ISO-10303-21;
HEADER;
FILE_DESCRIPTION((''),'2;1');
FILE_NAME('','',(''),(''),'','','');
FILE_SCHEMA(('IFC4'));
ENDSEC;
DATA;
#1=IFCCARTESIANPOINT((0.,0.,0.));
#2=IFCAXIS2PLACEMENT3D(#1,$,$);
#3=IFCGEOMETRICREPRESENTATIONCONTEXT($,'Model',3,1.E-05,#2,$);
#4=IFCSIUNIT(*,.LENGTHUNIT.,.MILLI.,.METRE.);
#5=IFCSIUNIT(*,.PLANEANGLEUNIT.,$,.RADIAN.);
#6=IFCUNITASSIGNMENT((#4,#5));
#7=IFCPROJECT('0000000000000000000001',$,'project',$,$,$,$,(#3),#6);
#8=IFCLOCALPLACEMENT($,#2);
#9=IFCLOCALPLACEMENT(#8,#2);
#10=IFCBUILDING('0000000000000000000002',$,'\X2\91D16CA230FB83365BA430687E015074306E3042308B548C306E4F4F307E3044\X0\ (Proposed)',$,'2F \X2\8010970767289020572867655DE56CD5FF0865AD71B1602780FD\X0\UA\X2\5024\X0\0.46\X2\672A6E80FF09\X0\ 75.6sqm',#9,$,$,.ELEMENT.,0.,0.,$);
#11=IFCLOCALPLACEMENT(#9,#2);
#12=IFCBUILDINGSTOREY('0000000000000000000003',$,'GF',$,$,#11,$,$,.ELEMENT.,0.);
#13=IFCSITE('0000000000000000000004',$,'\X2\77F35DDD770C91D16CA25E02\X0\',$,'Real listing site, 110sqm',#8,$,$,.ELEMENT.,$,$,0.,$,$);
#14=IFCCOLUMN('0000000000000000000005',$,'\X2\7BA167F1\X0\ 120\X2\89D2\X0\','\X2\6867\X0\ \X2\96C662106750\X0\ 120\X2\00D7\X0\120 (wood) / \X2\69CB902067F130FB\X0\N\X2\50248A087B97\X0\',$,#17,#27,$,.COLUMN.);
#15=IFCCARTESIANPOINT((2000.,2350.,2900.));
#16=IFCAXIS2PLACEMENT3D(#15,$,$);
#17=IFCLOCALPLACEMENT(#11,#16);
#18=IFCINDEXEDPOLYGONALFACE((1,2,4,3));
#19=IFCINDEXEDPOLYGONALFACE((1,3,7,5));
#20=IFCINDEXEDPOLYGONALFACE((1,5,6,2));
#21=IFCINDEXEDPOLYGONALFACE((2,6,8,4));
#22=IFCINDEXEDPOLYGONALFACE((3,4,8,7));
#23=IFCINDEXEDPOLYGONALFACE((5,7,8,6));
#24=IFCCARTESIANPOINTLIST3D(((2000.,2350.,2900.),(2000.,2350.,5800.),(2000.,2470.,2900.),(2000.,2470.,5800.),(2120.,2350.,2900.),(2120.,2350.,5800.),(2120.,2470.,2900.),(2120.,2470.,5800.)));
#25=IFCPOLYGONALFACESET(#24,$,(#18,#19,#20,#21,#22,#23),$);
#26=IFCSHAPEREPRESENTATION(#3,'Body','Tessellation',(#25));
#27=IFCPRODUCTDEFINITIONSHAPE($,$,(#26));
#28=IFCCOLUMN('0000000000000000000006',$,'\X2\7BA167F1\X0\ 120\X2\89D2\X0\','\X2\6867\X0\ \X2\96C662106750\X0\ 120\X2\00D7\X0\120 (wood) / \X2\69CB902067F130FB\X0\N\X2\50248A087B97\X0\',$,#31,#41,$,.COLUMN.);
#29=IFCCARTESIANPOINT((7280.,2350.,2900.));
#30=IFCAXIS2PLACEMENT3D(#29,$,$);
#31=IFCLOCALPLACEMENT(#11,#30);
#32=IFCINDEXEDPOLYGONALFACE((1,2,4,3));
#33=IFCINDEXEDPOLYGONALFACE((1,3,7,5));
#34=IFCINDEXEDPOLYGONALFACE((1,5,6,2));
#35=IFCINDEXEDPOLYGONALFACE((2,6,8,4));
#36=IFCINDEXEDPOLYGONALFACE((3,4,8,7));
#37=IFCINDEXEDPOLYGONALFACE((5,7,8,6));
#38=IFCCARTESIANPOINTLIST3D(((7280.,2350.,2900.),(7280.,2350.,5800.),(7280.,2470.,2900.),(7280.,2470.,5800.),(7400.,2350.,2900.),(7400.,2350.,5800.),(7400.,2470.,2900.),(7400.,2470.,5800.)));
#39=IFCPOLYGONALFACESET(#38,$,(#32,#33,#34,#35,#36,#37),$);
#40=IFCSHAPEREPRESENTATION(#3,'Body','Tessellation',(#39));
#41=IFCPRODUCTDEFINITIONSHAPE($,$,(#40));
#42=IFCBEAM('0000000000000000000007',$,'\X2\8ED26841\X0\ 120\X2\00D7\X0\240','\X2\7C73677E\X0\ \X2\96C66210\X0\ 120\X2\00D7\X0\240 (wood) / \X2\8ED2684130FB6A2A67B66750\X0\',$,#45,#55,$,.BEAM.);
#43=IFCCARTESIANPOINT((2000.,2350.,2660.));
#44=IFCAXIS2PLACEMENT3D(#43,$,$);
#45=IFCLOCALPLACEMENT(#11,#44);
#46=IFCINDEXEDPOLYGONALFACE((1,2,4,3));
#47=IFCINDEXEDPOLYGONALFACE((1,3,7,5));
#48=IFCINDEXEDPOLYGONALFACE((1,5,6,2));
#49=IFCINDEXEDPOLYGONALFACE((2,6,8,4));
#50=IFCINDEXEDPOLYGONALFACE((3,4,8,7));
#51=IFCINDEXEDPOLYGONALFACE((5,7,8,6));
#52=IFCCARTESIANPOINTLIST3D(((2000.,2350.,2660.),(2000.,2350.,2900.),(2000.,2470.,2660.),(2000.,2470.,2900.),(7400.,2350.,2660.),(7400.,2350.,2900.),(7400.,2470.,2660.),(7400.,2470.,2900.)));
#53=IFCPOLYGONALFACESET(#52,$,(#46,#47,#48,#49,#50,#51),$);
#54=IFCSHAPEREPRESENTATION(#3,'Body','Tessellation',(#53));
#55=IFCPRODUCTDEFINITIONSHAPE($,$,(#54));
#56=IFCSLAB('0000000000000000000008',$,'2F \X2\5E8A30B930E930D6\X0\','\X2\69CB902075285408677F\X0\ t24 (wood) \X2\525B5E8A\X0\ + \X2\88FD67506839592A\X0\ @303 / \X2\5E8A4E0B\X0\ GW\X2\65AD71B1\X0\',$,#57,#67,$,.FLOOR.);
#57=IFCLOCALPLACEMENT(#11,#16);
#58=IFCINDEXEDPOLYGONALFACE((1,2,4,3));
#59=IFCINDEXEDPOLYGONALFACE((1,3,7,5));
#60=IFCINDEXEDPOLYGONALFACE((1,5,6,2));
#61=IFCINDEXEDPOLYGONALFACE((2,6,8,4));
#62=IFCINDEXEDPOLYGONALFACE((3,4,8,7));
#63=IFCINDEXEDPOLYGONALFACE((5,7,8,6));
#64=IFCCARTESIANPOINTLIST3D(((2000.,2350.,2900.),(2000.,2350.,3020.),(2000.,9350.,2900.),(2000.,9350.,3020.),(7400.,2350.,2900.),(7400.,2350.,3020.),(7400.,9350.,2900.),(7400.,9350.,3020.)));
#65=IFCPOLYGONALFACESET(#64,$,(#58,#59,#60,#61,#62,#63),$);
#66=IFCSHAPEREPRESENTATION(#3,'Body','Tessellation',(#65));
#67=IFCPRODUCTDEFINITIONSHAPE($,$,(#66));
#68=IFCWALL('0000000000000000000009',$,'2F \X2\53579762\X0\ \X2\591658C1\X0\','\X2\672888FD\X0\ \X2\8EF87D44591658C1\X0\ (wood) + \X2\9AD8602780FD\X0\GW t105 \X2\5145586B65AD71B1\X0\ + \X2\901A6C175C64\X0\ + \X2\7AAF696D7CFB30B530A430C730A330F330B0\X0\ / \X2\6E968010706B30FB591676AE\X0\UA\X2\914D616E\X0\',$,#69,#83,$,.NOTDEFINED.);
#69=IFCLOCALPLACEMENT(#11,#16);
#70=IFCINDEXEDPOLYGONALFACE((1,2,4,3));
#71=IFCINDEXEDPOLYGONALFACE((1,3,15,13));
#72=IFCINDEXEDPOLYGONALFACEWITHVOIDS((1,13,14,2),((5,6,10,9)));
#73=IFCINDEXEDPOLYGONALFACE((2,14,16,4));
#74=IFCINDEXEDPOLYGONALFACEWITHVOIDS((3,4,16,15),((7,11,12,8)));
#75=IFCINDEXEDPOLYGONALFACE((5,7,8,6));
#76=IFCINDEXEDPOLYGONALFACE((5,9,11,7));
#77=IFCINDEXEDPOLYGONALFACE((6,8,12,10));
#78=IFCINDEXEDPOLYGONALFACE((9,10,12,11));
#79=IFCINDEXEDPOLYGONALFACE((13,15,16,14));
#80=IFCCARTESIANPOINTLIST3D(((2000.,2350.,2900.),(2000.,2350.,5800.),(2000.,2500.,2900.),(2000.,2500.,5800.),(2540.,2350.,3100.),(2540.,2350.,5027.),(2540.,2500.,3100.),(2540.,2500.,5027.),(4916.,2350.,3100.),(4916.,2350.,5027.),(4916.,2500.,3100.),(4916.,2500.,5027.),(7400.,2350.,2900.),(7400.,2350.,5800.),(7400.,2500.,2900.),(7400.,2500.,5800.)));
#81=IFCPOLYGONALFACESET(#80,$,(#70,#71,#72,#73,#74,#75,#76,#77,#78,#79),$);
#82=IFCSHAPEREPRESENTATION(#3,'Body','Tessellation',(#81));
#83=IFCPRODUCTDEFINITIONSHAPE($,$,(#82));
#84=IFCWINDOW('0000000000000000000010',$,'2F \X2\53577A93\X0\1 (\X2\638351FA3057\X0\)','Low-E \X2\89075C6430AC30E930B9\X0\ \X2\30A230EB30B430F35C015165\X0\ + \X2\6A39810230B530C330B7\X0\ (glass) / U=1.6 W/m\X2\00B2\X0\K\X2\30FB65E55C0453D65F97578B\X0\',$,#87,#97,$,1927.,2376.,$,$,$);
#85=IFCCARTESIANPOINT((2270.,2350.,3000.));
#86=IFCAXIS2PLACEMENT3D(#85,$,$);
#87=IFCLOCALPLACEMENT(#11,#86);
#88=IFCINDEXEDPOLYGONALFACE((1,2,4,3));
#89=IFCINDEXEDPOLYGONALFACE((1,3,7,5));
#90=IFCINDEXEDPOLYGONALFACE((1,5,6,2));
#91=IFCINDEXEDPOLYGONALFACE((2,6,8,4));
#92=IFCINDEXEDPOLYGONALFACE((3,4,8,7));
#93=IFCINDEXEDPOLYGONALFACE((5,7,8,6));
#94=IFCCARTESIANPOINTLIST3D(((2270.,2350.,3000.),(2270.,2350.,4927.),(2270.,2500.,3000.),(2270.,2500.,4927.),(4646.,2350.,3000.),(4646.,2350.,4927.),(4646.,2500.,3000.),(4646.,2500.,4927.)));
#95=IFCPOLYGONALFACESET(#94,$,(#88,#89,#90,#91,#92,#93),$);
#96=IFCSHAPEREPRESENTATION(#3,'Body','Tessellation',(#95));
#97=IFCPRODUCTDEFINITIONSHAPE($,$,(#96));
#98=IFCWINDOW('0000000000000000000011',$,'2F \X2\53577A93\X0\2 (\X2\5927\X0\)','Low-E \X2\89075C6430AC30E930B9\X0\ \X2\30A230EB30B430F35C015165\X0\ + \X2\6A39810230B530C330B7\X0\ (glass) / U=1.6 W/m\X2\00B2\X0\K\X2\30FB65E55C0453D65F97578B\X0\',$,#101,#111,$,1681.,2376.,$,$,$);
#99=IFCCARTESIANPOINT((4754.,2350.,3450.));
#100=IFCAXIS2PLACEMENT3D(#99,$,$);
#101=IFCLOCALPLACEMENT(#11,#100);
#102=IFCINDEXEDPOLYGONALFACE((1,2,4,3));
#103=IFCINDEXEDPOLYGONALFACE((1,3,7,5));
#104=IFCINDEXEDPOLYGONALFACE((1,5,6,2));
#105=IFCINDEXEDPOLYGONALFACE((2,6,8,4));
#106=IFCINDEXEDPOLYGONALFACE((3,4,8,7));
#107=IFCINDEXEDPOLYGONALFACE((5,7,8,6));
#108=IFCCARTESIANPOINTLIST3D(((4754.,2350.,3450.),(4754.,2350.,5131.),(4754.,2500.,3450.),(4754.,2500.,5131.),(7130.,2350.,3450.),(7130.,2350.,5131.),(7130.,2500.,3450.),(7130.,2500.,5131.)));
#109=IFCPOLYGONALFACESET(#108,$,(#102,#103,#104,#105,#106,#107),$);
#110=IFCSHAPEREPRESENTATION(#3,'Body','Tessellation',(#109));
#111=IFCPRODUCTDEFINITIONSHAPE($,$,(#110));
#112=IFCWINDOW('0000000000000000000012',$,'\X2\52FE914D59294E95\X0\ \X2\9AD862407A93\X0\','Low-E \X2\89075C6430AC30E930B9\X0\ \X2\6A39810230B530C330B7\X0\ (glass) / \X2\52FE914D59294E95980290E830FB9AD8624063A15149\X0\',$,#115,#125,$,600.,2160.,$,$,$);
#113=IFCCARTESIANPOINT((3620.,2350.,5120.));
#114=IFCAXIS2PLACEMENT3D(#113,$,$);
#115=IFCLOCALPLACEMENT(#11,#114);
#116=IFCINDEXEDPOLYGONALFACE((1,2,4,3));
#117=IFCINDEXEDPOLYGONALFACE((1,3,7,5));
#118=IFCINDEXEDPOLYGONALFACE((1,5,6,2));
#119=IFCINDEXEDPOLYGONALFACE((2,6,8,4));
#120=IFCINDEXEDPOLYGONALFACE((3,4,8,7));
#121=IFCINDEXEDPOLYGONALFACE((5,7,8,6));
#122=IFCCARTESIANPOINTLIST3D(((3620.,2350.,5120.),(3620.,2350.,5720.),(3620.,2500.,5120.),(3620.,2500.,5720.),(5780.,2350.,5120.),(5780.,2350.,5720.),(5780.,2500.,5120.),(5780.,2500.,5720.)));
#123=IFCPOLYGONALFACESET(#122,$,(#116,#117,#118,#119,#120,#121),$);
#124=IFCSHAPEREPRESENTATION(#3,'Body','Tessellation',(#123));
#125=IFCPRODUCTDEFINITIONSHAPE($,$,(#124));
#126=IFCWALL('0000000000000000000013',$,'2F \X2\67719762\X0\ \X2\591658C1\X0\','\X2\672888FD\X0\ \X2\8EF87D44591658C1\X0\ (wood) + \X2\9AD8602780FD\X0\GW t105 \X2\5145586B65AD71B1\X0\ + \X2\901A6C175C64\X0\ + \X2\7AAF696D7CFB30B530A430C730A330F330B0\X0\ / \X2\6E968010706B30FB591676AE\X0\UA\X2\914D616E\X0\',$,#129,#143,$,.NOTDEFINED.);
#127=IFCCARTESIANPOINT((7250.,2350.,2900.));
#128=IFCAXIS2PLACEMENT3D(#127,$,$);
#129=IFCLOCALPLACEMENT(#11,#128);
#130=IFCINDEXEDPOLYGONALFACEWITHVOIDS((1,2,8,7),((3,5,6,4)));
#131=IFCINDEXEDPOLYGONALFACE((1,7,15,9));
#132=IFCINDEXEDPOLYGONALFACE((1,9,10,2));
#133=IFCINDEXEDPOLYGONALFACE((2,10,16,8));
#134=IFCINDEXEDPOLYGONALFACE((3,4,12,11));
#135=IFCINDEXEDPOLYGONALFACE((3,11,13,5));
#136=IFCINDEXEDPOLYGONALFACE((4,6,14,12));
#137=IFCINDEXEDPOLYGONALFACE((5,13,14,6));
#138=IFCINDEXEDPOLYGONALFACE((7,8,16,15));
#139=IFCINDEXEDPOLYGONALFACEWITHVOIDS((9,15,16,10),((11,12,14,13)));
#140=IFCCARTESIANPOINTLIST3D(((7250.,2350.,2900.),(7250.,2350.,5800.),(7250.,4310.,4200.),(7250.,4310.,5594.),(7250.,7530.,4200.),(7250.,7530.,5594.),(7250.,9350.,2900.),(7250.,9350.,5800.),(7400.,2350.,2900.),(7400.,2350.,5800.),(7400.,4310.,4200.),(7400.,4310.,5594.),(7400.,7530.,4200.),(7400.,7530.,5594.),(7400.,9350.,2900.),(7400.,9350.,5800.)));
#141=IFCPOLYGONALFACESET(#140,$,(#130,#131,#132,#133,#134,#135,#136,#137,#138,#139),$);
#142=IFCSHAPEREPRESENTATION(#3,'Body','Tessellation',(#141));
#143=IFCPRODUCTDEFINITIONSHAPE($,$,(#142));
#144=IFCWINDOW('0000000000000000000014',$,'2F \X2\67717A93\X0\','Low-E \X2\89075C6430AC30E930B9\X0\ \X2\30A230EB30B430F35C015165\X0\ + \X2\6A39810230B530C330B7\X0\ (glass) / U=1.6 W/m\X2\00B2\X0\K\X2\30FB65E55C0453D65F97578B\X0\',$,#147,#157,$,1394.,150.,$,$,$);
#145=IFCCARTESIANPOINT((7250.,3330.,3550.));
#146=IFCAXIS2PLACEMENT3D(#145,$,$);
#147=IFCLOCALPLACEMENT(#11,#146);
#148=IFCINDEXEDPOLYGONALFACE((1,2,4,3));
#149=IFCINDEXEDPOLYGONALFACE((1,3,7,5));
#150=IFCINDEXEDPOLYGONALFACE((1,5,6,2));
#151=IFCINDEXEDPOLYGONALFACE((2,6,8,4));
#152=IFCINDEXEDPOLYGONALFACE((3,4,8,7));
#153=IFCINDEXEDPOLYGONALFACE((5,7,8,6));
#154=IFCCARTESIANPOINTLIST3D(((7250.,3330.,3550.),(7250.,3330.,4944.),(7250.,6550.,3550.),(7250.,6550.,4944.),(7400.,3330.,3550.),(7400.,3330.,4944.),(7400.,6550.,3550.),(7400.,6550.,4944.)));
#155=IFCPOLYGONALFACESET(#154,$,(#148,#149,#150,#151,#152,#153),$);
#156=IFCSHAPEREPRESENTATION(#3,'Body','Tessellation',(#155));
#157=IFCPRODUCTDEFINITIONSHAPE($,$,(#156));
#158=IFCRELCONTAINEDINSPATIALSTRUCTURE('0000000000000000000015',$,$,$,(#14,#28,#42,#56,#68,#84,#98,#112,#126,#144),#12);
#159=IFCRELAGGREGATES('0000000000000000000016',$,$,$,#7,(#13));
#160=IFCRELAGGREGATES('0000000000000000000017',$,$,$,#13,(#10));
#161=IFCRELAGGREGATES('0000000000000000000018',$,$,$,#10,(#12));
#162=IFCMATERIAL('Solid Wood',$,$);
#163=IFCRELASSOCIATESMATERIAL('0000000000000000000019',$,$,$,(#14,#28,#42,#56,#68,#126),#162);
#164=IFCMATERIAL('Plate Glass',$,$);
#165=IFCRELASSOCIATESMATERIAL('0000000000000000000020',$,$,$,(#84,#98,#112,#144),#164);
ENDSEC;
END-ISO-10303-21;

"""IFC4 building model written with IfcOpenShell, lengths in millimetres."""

from ifc_helpers import new_model, si_unit, frame, frame_2d, origin, place, context, project, spatial, rectangle, extrude, material, element, fill, save


model = new_model("IFC4")

# Units and contexts
model_context = context("Model", 3, precision=1e-05, world=origin())
ifc_project = project(units=[si_unit("LENGTHUNIT", "METRE", prefix="MILLI"), si_unit("PLANEANGLEUNIT", "RADIAN")], contexts=[model_context])

# Site, building, storey
site_placement = place(None, origin())
site = spatial("IfcSite", under=ifc_project, at=site_placement, Name="石川県金沢市", ObjectType="Real listing site, 110sqm", CompositionType="ELEMENT", RefElevation=0.0)
building_placement = place(site_placement, origin())
building = spatial("IfcBuilding", under=site, at=building_placement, Name="金沢・茶室と縁側のある和の住まい (Proposed)", ObjectType="2F 耐震木造在来工法（断熱性能UA値0.46未満） 75.6sqm", CompositionType="ELEMENT", ElevationOfRefHeight=0.0, ElevationOfTerrain=0.0)
storey_placement = place(building_placement, origin())
storey = spatial("IfcBuildingStorey", under=building, at=storey_placement, Name="GF", CompositionType="ELEMENT", Elevation=0.0)

# Columns
ifc_material_1 = material(Name="Solid Wood")
column_1_placement = place(storey_placement, frame((2000.0, 2350.0, 2900.0)))
element("IfcColumn", 1, at=column_1_placement, inside=storey, material=ifc_material_1, Name="管柱 120角", Description="桧 集成材 120×120 (wood) / 構造柱・N値計算", PredefinedType="COLUMN", context=model_context, shape_type="SweptSolid", body=[
    extrude(rectangle(XDim=120.0, YDim=120.0, at=frame_2d((60.0, 60.0))), frame((2000.0, 2350.0, 2900.0)), (0.0, 0.0, 1.0), 2900.0),
])
column_2_placement = place(storey_placement, frame((7280.0, 2350.0, 2900.0)))
element("IfcColumn", 2, at=column_2_placement, inside=storey, material=ifc_material_1, Name="管柱 120角", Description="桧 集成材 120×120 (wood) / 構造柱・N値計算", PredefinedType="COLUMN", context=model_context, shape_type="SweptSolid", body=[
    extrude(rectangle(XDim=120.0, YDim=120.0, at=frame_2d((60.0, 60.0))), frame((7280.0, 2350.0, 2900.0)), (0.0, 0.0, 1.0), 2900.0),
])

# Beam
beam_1_placement = place(storey_placement, frame((2000.0, 2350.0, 2660.0)))
element("IfcBeam", 3, at=beam_1_placement, inside=storey, material=ifc_material_1, Name="軒桁 120×240", Description="米松 集成 120×240 (wood) / 軒桁・横架材", PredefinedType="BEAM", context=model_context, shape_type="SweptSolid", body=[
    extrude(rectangle(XDim=5400.0, YDim=120.0, at=frame_2d((2700.0, 60.0))), frame((2000.0, 2350.0, 2660.0)), (0.0, 0.0, 1.0), 240.0),
])

# Slab
slab_placement = place(storey_placement, frame((2000.0, 2350.0, 2900.0)))
element("IfcSlab", 4, at=slab_placement, inside=storey, material=ifc_material_1, Name="2F 床スラブ", Description="構造用合板 t24 (wood) 剛床 + 製材根太 @303 / 床下 GW断熱", PredefinedType="FLOOR", context=model_context, shape_type="SweptSolid", body=[
    extrude(rectangle(XDim=5400.0, YDim=7000.0, at=frame_2d((2700.0, 3500.0))), frame((2000.0, 2350.0, 2900.0)), (0.0, 0.0, 1.0), 120.0),
])

# Wall, openings, windows
wall_1_placement = place(storey_placement, frame((2000.0, 2350.0, 2900.0)))
wall_1 = element("IfcWall", 5, at=wall_1_placement, inside=storey, material=ifc_material_1, Name="2F 南面 外壁", Description="木製 軸組外壁 (wood) + 高性能GW t105 充填断熱 + 通気層 + 窯業系サイディング / 準耐火・外皮UA配慮", PredefinedType="NOTDEFINED", context=model_context, shape_type="SweptSolid", body=[
    extrude(rectangle(XDim=5400.0, YDim=150.0, at=frame_2d((2700.0, 75.0))), frame((2000.0, 2350.0, 2900.0)), (0.0, 0.0, 1.0), 2900.0),
])
opening_1_placement = place(storey_placement, frame((2270.0, 2350.0, 3000.0)))
opening_1 = element("IfcOpeningElement", 6, at=opening_1_placement, cuts=wall_1, PredefinedType="NOTDEFINED", context=model_context, shape_type="SweptSolid", body=[
    extrude(rectangle(XDim=2376.0, YDim=150.0, at=frame_2d((1188.0, 75.0))), frame((2270.0, 2350.0, 3000.0)), (0.0, 0.0, 1.0), 1927.0),
])
opening_2_placement = place(storey_placement, frame((4754.0, 2350.0, 3450.0)))
opening_2 = element("IfcOpeningElement", 7, at=opening_2_placement, cuts=wall_1, PredefinedType="NOTDEFINED", context=model_context, shape_type="SweptSolid", body=[
    extrude(rectangle(XDim=2376.0, YDim=150.0, at=frame_2d((1188.0, 75.0))), frame((4754.0, 2350.0, 3450.0)), (0.0, 0.0, 1.0), 1681.0),
])
opening_3_placement = place(storey_placement, frame((3620.0, 2350.0, 5120.0)))
opening_3 = element("IfcOpeningElement", 8, at=opening_3_placement, cuts=wall_1, PredefinedType="NOTDEFINED", context=model_context, shape_type="SweptSolid", body=[
    extrude(rectangle(XDim=2160.0, YDim=150.0, at=frame_2d((1080.0, 75.0))), frame((3620.0, 2350.0, 5120.0)), (0.0, 0.0, 1.0), 600.0),
])
ifc_material_2 = material(Name="Plate Glass")
window_1_placement = place(storey_placement, frame((2270.0, 2350.0, 3000.0)))
window_1 = element("IfcWindow", 9, at=window_1_placement, inside=storey, material=ifc_material_2, Name="2F 南窓1 (掃出し)", Description="Low-E 複層ガラス アルゴン封入 + 樹脂サッシ (glass) / U=1.6 W/m²K・日射取得型", OverallHeight=1927.0, OverallWidth=2376.0, context=model_context, shape_type="SweptSolid", body=[
    extrude(rectangle(XDim=2376.0, YDim=150.0, at=frame_2d((1188.0, 75.0))), frame((2270.0, 2350.0, 3000.0)), (0.0, 0.0, 1.0), 1927.0),
])
fill(opening_1, window_1)
window_2_placement = place(storey_placement, frame((4754.0, 2350.0, 3450.0)))
window_2 = element("IfcWindow", 10, at=window_2_placement, inside=storey, material=ifc_material_2, Name="2F 南窓2 (大)", Description="Low-E 複層ガラス アルゴン封入 + 樹脂サッシ (glass) / U=1.6 W/m²K・日射取得型", OverallHeight=1681.0, OverallWidth=2376.0, context=model_context, shape_type="SweptSolid", body=[
    extrude(rectangle(XDim=2376.0, YDim=150.0, at=frame_2d((1188.0, 75.0))), frame((4754.0, 2350.0, 3450.0)), (0.0, 0.0, 1.0), 1681.0),
])
fill(opening_2, window_2)
window_3_placement = place(storey_placement, frame((3620.0, 2350.0, 5120.0)))
window_3 = element("IfcWindow", 11, at=window_3_placement, inside=storey, material=ifc_material_2, Name="勾配天井 高所窓", Description="Low-E 複層ガラス 樹脂サッシ (glass) / 勾配天井頂部・高所採光", OverallHeight=600.0, OverallWidth=2160.0, context=model_context, shape_type="SweptSolid", body=[
    extrude(rectangle(XDim=2160.0, YDim=150.0, at=frame_2d((1080.0, 75.0))), frame((3620.0, 2350.0, 5120.0)), (0.0, 0.0, 1.0), 600.0),
])
fill(opening_3, window_3)

# Wall, opening, window
wall_2_placement = place(storey_placement, frame((7250.0, 2350.0, 2900.0)))
wall_2 = element("IfcWall", 12, at=wall_2_placement, inside=storey, material=ifc_material_1, Name="2F 東面 外壁", Description="木製 軸組外壁 (wood) + 高性能GW t105 充填断熱 + 通気層 + 窯業系サイディング / 準耐火・外皮UA配慮", PredefinedType="NOTDEFINED", context=model_context, shape_type="SweptSolid", body=[
    extrude(rectangle(XDim=150.0, YDim=7000.0, at=frame_2d((75.0, 3500.0))), frame((7250.0, 2350.0, 2900.0)), (0.0, 0.0, 1.0), 2900.0),
])
opening_4_placement = place(storey_placement, frame((7250.0, 3330.0, 3550.0)))
opening_4 = element("IfcOpeningElement", 13, at=opening_4_placement, cuts=wall_2, PredefinedType="NOTDEFINED", context=model_context, shape_type="SweptSolid", body=[
    extrude(rectangle(XDim=150.0, YDim=3220.0, at=frame_2d((75.0, 1610.0))), frame((7250.0, 3330.0, 3550.0)), (0.0, 0.0, 1.0), 1394.0),
])
window_4_placement = place(storey_placement, frame((7250.0, 3330.0, 3550.0)))
window_4 = element("IfcWindow", 14, at=window_4_placement, inside=storey, material=ifc_material_2, Name="2F 東窓", Description="Low-E 複層ガラス アルゴン封入 + 樹脂サッシ (glass) / U=1.6 W/m²K・日射取得型", OverallHeight=1394.0, OverallWidth=150.0, context=model_context, shape_type="SweptSolid", body=[
    extrude(rectangle(XDim=150.0, YDim=3220.0, at=frame_2d((75.0, 1610.0))), frame((7250.0, 3330.0, 3550.0)), (0.0, 0.0, 1.0), 1394.0),
])
fill(opening_4, window_4)

save(model, "model.ifc")
